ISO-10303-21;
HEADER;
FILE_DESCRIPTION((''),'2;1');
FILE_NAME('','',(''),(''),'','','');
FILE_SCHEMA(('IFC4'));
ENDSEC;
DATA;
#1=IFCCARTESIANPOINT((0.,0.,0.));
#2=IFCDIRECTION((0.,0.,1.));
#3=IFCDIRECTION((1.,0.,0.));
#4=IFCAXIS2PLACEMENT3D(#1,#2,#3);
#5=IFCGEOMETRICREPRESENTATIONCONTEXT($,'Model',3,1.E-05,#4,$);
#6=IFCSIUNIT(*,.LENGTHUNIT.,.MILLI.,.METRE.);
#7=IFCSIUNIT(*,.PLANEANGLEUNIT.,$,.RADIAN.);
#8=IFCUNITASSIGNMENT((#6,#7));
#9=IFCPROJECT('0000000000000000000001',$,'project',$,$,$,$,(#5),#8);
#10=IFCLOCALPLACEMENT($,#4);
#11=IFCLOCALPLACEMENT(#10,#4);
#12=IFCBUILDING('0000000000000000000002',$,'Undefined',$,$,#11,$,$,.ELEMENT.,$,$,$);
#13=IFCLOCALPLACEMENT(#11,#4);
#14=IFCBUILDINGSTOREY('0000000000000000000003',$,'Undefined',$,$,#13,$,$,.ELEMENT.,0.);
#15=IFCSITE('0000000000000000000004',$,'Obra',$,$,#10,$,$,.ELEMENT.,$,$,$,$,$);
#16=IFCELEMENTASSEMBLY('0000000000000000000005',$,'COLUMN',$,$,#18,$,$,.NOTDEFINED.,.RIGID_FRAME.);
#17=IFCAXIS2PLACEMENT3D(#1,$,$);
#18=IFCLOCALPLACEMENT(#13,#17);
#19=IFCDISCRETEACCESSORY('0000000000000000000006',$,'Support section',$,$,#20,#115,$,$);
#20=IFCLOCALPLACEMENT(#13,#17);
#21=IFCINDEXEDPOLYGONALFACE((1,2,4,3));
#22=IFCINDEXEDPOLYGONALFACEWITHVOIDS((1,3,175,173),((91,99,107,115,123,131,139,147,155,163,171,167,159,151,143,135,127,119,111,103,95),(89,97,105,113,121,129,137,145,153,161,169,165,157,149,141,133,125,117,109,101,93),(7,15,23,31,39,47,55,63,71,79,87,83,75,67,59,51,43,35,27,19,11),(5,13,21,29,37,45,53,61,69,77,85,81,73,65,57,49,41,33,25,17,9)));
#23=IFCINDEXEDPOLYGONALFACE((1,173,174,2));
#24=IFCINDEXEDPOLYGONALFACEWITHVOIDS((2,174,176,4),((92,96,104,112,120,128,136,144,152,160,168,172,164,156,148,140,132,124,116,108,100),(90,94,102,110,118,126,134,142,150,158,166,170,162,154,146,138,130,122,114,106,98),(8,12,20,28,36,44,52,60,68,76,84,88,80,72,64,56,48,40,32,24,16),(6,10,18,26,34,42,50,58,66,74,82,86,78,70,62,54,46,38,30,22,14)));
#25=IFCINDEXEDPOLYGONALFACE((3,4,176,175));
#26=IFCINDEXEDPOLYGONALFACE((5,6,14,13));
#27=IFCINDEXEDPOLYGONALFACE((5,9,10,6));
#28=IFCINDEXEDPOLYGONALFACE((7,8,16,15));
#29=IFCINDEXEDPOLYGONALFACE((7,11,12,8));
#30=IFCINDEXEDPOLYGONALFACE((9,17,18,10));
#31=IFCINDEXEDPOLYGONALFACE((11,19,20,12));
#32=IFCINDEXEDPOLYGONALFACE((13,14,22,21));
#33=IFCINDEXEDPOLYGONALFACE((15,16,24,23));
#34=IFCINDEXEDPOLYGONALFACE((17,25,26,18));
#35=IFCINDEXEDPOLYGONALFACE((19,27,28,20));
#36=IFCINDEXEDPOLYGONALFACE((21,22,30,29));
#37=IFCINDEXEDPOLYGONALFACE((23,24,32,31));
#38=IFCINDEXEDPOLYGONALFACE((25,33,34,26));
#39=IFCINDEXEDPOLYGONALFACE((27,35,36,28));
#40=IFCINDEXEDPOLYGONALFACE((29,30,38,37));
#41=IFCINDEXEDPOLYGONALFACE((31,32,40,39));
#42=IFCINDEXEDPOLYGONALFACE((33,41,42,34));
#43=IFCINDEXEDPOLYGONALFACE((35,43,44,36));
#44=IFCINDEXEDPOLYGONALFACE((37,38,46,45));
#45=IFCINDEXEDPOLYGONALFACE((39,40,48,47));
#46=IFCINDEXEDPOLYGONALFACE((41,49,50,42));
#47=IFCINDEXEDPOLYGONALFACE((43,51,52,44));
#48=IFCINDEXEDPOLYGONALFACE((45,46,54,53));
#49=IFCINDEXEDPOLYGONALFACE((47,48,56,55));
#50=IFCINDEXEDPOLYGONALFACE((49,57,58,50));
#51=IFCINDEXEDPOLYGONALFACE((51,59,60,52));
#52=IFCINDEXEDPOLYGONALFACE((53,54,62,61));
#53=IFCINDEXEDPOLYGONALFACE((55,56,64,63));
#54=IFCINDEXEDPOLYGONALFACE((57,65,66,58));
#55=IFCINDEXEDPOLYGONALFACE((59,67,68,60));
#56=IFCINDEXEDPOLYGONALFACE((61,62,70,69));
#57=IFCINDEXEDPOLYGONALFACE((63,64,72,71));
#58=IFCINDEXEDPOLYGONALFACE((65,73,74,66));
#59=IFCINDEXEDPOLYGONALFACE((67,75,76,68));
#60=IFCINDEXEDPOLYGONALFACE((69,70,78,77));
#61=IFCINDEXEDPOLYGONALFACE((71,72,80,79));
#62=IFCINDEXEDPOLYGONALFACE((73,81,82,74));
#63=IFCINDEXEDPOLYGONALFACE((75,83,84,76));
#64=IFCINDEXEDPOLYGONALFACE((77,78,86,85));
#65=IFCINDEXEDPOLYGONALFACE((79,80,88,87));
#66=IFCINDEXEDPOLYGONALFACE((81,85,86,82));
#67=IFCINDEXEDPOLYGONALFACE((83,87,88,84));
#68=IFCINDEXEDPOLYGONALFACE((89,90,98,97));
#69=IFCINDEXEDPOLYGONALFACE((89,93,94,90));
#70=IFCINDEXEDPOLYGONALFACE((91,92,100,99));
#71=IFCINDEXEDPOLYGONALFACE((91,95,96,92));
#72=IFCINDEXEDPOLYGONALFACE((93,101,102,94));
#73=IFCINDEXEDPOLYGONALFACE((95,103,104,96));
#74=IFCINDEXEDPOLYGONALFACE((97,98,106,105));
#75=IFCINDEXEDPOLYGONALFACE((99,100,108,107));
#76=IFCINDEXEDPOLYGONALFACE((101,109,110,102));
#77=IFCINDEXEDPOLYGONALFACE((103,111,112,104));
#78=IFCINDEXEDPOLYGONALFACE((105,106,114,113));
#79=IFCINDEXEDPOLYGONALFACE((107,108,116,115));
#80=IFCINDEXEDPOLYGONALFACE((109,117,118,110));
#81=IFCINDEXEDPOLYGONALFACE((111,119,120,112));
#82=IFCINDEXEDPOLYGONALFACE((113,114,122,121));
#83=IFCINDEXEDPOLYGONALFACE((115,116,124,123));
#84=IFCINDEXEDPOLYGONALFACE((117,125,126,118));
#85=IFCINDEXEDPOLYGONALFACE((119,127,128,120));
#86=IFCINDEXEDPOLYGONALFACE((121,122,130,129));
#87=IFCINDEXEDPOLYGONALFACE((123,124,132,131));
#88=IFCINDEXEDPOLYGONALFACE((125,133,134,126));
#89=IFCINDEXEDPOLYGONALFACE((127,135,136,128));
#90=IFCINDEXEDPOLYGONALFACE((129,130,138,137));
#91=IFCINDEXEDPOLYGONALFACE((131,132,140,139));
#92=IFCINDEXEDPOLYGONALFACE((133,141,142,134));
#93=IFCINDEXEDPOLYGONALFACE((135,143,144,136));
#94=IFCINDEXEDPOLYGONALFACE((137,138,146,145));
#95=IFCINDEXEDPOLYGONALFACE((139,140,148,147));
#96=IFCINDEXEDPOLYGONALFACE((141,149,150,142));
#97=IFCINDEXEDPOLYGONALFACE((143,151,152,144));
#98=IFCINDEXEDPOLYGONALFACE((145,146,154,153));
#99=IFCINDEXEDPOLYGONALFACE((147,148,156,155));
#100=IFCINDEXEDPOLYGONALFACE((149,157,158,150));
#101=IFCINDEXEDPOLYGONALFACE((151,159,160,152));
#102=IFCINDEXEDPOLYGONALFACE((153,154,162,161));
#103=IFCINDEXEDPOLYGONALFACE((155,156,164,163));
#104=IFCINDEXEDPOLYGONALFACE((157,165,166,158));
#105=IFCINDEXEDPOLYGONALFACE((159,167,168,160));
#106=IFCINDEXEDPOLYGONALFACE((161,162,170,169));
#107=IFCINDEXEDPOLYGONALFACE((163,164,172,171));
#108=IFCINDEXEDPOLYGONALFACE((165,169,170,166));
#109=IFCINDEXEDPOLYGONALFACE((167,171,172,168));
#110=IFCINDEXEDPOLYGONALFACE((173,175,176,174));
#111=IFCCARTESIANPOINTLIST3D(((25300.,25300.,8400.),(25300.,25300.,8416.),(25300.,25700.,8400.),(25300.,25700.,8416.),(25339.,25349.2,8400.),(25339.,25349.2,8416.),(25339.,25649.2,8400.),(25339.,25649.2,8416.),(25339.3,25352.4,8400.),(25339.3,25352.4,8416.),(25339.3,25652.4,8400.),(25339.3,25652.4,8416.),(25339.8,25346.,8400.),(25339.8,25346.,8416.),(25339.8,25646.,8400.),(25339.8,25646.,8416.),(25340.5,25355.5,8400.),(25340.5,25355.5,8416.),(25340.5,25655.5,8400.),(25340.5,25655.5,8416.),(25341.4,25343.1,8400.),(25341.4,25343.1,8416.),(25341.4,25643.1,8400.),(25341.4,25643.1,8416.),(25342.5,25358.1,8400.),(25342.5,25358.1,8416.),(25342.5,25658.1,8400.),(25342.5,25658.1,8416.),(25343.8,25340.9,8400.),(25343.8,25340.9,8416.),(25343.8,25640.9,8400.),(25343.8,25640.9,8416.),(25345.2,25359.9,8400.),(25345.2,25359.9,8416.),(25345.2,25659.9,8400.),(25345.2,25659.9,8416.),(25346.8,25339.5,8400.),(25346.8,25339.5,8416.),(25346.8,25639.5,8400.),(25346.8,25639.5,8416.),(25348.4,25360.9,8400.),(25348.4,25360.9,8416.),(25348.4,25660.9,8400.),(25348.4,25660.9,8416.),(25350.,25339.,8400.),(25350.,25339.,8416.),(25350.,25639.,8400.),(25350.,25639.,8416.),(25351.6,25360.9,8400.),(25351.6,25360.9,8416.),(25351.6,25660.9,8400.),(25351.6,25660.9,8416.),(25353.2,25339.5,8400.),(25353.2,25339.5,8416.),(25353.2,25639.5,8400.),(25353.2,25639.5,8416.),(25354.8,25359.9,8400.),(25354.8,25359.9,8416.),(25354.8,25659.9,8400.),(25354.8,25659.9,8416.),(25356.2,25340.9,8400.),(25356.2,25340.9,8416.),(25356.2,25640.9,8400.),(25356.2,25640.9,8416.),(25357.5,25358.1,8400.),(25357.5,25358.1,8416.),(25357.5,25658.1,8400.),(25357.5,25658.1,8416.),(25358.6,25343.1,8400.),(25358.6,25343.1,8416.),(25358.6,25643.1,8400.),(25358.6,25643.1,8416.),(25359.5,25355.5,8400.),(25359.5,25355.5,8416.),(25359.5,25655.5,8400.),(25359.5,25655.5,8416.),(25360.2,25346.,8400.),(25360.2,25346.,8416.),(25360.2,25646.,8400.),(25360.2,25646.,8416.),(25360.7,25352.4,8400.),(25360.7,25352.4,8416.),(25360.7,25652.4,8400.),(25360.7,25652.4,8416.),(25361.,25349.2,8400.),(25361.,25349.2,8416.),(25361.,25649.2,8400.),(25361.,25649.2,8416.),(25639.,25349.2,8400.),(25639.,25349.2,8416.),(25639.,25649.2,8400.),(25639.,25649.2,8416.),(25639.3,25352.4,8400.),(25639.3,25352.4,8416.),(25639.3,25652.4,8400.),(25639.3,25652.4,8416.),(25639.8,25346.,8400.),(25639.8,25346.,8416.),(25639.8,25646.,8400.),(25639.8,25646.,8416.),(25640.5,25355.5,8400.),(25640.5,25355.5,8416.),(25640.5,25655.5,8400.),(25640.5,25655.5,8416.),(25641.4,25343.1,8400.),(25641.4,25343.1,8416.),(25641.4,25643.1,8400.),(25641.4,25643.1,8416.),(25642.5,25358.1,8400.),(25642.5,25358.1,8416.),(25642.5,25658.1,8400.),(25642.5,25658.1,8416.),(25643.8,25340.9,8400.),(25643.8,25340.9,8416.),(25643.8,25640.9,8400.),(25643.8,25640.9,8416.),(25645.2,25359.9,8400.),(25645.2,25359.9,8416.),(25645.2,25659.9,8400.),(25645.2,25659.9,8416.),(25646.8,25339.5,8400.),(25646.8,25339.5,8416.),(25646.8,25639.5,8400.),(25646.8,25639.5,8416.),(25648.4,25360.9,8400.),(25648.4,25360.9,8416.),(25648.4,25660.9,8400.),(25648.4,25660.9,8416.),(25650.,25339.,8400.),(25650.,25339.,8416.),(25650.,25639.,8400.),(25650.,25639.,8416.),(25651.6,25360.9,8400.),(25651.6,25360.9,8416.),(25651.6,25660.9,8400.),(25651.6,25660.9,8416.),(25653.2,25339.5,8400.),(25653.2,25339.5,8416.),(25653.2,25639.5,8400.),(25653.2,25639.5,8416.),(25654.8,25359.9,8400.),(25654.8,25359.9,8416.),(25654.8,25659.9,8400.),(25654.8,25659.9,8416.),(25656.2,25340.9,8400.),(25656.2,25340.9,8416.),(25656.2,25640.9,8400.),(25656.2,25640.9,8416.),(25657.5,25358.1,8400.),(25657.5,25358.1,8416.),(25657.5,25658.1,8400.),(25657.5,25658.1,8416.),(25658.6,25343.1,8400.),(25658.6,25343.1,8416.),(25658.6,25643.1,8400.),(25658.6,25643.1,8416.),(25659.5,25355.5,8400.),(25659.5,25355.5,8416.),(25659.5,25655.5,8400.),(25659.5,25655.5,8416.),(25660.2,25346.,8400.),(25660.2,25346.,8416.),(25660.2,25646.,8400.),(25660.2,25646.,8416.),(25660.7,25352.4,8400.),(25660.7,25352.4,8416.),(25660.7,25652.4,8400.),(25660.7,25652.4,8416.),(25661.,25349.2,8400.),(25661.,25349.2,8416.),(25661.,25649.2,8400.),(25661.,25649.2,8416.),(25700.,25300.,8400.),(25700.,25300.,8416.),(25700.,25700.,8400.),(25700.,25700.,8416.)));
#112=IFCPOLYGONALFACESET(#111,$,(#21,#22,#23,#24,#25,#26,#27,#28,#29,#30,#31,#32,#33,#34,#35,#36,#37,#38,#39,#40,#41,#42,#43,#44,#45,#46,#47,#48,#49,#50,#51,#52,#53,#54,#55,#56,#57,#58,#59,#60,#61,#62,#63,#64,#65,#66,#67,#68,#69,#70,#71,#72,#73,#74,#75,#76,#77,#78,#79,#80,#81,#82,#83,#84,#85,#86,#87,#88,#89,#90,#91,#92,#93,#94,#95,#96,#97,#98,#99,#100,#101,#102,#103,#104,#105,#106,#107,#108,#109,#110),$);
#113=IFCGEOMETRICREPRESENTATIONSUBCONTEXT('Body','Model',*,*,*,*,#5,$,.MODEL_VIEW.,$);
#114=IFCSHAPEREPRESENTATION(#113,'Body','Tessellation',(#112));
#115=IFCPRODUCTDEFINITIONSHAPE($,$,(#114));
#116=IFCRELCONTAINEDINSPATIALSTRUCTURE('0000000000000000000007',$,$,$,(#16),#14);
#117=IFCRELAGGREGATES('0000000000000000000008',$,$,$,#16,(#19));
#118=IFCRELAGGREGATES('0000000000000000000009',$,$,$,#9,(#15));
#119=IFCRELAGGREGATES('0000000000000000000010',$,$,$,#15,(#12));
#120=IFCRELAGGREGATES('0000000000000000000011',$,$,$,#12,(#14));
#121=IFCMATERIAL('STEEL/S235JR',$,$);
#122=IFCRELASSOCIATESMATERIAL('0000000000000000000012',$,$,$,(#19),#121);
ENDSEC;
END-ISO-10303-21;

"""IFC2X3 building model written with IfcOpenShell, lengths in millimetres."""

from ifc_helpers import new_model, si_unit, frame, origin_with_axes, origin_2d_with_axis, place, context, subcontext, project, spatial, rectangle, circle, extrude, source, transform, mapped, material, element, aggregate, save


model = new_model("IFC2X3")

# Units and contexts
model_context = context("Model", 3, precision=1e-05, world=origin_with_axes())
body_context = subcontext(model_context, "Body", "Model", "MODEL_VIEW")
ifc_project = project(units=[si_unit("LENGTHUNIT", "METRE", prefix="MILLI"), si_unit("PLANEANGLEUNIT", "RADIAN")], contexts=[model_context])

# Site, building, storey
site_placement = place(None, origin_with_axes())
site = spatial("IfcSite", under=ifc_project, at=site_placement, Name="Obra", CompositionType="ELEMENT")
building_placement = place(site_placement, origin_with_axes())
building = spatial("IfcBuilding", under=site, at=building_placement, Name="Undefined", CompositionType="ELEMENT")
storey_placement = place(building_placement, origin_with_axes())
storey = spatial("IfcBuildingStorey", under=building, at=storey_placement, Name="Undefined", CompositionType="ELEMENT", Elevation=0.0)

# Element assembly
assembly_1_placement = place(storey_placement, origin_with_axes())
assembly_1 = element("IfcElementAssembly", 1, at=assembly_1_placement, inside=storey, Name="COLUMN", AssemblyPlace="NOTDEFINED", PredefinedType="RIGID_FRAME")
ifc_material_1 = material(Name="STEEL/S235JR")

# Discrete accessory, opening
discrete_accessory_1_placement = place(assembly_1_placement, frame((25500.0, 25300.0, 8408.0), z_axis=(-1.0, 0.0, 0.0), x_axis=(0.0, 1.0, 0.0)))
discrete_accessory_1 = element("IfcDiscreteAccessory", 2, at=discrete_accessory_1_placement, material=ifc_material_1, Name="Support section", context=body_context, shape_type="SweptSolid", body=[
    extrude(rectangle(XDim=16.0, YDim=400.0, at=origin_2d_with_axis()), frame((400.0, 0.0, 0.0), z_axis=(-1.0, 0.0, 0.0), x_axis=(0.0, -1.0, 0.0)), (0.0, 0.0, 1.0), 400.0),
])
shared_shape_1 = source(origin_with_axes(), body_context, "Body", "SweptSolid", [
    extrude(circle(Radius=11.0, at=origin_2d_with_axis()), frame((0.0, -0.1, 0.0), z_axis=(0.0, 1.0, 0.0), x_axis=(1.0, 0.0, 0.0)), (0.0, 0.0, 1.0), 16.2),
])
opening_1_placement = place(assembly_1_placement, frame((25500.0, 25652.5, 8416.0), z_axis=(1.0, 0.0, 0.0), x_axis=(0.0, -1.0, 0.0)))
element("IfcOpeningElement", 3, at=opening_1_placement, cuts=discrete_accessory_1, ObjectType="Opening", context=body_context, shape_type="MappedRepresentation", body=[
    mapped(shared_shape_1, transform((2.5, 0.0, 150.0))),
    mapped(shared_shape_1, transform((2.5, 0.0, -150.0))),
    mapped(shared_shape_1, transform((302.5, 0.0, 150.0))),
    mapped(shared_shape_1, transform((302.5, 0.0, -150.0))),
])
aggregate(assembly_1, [discrete_accessory_1])

save(model, "model.ifc")
